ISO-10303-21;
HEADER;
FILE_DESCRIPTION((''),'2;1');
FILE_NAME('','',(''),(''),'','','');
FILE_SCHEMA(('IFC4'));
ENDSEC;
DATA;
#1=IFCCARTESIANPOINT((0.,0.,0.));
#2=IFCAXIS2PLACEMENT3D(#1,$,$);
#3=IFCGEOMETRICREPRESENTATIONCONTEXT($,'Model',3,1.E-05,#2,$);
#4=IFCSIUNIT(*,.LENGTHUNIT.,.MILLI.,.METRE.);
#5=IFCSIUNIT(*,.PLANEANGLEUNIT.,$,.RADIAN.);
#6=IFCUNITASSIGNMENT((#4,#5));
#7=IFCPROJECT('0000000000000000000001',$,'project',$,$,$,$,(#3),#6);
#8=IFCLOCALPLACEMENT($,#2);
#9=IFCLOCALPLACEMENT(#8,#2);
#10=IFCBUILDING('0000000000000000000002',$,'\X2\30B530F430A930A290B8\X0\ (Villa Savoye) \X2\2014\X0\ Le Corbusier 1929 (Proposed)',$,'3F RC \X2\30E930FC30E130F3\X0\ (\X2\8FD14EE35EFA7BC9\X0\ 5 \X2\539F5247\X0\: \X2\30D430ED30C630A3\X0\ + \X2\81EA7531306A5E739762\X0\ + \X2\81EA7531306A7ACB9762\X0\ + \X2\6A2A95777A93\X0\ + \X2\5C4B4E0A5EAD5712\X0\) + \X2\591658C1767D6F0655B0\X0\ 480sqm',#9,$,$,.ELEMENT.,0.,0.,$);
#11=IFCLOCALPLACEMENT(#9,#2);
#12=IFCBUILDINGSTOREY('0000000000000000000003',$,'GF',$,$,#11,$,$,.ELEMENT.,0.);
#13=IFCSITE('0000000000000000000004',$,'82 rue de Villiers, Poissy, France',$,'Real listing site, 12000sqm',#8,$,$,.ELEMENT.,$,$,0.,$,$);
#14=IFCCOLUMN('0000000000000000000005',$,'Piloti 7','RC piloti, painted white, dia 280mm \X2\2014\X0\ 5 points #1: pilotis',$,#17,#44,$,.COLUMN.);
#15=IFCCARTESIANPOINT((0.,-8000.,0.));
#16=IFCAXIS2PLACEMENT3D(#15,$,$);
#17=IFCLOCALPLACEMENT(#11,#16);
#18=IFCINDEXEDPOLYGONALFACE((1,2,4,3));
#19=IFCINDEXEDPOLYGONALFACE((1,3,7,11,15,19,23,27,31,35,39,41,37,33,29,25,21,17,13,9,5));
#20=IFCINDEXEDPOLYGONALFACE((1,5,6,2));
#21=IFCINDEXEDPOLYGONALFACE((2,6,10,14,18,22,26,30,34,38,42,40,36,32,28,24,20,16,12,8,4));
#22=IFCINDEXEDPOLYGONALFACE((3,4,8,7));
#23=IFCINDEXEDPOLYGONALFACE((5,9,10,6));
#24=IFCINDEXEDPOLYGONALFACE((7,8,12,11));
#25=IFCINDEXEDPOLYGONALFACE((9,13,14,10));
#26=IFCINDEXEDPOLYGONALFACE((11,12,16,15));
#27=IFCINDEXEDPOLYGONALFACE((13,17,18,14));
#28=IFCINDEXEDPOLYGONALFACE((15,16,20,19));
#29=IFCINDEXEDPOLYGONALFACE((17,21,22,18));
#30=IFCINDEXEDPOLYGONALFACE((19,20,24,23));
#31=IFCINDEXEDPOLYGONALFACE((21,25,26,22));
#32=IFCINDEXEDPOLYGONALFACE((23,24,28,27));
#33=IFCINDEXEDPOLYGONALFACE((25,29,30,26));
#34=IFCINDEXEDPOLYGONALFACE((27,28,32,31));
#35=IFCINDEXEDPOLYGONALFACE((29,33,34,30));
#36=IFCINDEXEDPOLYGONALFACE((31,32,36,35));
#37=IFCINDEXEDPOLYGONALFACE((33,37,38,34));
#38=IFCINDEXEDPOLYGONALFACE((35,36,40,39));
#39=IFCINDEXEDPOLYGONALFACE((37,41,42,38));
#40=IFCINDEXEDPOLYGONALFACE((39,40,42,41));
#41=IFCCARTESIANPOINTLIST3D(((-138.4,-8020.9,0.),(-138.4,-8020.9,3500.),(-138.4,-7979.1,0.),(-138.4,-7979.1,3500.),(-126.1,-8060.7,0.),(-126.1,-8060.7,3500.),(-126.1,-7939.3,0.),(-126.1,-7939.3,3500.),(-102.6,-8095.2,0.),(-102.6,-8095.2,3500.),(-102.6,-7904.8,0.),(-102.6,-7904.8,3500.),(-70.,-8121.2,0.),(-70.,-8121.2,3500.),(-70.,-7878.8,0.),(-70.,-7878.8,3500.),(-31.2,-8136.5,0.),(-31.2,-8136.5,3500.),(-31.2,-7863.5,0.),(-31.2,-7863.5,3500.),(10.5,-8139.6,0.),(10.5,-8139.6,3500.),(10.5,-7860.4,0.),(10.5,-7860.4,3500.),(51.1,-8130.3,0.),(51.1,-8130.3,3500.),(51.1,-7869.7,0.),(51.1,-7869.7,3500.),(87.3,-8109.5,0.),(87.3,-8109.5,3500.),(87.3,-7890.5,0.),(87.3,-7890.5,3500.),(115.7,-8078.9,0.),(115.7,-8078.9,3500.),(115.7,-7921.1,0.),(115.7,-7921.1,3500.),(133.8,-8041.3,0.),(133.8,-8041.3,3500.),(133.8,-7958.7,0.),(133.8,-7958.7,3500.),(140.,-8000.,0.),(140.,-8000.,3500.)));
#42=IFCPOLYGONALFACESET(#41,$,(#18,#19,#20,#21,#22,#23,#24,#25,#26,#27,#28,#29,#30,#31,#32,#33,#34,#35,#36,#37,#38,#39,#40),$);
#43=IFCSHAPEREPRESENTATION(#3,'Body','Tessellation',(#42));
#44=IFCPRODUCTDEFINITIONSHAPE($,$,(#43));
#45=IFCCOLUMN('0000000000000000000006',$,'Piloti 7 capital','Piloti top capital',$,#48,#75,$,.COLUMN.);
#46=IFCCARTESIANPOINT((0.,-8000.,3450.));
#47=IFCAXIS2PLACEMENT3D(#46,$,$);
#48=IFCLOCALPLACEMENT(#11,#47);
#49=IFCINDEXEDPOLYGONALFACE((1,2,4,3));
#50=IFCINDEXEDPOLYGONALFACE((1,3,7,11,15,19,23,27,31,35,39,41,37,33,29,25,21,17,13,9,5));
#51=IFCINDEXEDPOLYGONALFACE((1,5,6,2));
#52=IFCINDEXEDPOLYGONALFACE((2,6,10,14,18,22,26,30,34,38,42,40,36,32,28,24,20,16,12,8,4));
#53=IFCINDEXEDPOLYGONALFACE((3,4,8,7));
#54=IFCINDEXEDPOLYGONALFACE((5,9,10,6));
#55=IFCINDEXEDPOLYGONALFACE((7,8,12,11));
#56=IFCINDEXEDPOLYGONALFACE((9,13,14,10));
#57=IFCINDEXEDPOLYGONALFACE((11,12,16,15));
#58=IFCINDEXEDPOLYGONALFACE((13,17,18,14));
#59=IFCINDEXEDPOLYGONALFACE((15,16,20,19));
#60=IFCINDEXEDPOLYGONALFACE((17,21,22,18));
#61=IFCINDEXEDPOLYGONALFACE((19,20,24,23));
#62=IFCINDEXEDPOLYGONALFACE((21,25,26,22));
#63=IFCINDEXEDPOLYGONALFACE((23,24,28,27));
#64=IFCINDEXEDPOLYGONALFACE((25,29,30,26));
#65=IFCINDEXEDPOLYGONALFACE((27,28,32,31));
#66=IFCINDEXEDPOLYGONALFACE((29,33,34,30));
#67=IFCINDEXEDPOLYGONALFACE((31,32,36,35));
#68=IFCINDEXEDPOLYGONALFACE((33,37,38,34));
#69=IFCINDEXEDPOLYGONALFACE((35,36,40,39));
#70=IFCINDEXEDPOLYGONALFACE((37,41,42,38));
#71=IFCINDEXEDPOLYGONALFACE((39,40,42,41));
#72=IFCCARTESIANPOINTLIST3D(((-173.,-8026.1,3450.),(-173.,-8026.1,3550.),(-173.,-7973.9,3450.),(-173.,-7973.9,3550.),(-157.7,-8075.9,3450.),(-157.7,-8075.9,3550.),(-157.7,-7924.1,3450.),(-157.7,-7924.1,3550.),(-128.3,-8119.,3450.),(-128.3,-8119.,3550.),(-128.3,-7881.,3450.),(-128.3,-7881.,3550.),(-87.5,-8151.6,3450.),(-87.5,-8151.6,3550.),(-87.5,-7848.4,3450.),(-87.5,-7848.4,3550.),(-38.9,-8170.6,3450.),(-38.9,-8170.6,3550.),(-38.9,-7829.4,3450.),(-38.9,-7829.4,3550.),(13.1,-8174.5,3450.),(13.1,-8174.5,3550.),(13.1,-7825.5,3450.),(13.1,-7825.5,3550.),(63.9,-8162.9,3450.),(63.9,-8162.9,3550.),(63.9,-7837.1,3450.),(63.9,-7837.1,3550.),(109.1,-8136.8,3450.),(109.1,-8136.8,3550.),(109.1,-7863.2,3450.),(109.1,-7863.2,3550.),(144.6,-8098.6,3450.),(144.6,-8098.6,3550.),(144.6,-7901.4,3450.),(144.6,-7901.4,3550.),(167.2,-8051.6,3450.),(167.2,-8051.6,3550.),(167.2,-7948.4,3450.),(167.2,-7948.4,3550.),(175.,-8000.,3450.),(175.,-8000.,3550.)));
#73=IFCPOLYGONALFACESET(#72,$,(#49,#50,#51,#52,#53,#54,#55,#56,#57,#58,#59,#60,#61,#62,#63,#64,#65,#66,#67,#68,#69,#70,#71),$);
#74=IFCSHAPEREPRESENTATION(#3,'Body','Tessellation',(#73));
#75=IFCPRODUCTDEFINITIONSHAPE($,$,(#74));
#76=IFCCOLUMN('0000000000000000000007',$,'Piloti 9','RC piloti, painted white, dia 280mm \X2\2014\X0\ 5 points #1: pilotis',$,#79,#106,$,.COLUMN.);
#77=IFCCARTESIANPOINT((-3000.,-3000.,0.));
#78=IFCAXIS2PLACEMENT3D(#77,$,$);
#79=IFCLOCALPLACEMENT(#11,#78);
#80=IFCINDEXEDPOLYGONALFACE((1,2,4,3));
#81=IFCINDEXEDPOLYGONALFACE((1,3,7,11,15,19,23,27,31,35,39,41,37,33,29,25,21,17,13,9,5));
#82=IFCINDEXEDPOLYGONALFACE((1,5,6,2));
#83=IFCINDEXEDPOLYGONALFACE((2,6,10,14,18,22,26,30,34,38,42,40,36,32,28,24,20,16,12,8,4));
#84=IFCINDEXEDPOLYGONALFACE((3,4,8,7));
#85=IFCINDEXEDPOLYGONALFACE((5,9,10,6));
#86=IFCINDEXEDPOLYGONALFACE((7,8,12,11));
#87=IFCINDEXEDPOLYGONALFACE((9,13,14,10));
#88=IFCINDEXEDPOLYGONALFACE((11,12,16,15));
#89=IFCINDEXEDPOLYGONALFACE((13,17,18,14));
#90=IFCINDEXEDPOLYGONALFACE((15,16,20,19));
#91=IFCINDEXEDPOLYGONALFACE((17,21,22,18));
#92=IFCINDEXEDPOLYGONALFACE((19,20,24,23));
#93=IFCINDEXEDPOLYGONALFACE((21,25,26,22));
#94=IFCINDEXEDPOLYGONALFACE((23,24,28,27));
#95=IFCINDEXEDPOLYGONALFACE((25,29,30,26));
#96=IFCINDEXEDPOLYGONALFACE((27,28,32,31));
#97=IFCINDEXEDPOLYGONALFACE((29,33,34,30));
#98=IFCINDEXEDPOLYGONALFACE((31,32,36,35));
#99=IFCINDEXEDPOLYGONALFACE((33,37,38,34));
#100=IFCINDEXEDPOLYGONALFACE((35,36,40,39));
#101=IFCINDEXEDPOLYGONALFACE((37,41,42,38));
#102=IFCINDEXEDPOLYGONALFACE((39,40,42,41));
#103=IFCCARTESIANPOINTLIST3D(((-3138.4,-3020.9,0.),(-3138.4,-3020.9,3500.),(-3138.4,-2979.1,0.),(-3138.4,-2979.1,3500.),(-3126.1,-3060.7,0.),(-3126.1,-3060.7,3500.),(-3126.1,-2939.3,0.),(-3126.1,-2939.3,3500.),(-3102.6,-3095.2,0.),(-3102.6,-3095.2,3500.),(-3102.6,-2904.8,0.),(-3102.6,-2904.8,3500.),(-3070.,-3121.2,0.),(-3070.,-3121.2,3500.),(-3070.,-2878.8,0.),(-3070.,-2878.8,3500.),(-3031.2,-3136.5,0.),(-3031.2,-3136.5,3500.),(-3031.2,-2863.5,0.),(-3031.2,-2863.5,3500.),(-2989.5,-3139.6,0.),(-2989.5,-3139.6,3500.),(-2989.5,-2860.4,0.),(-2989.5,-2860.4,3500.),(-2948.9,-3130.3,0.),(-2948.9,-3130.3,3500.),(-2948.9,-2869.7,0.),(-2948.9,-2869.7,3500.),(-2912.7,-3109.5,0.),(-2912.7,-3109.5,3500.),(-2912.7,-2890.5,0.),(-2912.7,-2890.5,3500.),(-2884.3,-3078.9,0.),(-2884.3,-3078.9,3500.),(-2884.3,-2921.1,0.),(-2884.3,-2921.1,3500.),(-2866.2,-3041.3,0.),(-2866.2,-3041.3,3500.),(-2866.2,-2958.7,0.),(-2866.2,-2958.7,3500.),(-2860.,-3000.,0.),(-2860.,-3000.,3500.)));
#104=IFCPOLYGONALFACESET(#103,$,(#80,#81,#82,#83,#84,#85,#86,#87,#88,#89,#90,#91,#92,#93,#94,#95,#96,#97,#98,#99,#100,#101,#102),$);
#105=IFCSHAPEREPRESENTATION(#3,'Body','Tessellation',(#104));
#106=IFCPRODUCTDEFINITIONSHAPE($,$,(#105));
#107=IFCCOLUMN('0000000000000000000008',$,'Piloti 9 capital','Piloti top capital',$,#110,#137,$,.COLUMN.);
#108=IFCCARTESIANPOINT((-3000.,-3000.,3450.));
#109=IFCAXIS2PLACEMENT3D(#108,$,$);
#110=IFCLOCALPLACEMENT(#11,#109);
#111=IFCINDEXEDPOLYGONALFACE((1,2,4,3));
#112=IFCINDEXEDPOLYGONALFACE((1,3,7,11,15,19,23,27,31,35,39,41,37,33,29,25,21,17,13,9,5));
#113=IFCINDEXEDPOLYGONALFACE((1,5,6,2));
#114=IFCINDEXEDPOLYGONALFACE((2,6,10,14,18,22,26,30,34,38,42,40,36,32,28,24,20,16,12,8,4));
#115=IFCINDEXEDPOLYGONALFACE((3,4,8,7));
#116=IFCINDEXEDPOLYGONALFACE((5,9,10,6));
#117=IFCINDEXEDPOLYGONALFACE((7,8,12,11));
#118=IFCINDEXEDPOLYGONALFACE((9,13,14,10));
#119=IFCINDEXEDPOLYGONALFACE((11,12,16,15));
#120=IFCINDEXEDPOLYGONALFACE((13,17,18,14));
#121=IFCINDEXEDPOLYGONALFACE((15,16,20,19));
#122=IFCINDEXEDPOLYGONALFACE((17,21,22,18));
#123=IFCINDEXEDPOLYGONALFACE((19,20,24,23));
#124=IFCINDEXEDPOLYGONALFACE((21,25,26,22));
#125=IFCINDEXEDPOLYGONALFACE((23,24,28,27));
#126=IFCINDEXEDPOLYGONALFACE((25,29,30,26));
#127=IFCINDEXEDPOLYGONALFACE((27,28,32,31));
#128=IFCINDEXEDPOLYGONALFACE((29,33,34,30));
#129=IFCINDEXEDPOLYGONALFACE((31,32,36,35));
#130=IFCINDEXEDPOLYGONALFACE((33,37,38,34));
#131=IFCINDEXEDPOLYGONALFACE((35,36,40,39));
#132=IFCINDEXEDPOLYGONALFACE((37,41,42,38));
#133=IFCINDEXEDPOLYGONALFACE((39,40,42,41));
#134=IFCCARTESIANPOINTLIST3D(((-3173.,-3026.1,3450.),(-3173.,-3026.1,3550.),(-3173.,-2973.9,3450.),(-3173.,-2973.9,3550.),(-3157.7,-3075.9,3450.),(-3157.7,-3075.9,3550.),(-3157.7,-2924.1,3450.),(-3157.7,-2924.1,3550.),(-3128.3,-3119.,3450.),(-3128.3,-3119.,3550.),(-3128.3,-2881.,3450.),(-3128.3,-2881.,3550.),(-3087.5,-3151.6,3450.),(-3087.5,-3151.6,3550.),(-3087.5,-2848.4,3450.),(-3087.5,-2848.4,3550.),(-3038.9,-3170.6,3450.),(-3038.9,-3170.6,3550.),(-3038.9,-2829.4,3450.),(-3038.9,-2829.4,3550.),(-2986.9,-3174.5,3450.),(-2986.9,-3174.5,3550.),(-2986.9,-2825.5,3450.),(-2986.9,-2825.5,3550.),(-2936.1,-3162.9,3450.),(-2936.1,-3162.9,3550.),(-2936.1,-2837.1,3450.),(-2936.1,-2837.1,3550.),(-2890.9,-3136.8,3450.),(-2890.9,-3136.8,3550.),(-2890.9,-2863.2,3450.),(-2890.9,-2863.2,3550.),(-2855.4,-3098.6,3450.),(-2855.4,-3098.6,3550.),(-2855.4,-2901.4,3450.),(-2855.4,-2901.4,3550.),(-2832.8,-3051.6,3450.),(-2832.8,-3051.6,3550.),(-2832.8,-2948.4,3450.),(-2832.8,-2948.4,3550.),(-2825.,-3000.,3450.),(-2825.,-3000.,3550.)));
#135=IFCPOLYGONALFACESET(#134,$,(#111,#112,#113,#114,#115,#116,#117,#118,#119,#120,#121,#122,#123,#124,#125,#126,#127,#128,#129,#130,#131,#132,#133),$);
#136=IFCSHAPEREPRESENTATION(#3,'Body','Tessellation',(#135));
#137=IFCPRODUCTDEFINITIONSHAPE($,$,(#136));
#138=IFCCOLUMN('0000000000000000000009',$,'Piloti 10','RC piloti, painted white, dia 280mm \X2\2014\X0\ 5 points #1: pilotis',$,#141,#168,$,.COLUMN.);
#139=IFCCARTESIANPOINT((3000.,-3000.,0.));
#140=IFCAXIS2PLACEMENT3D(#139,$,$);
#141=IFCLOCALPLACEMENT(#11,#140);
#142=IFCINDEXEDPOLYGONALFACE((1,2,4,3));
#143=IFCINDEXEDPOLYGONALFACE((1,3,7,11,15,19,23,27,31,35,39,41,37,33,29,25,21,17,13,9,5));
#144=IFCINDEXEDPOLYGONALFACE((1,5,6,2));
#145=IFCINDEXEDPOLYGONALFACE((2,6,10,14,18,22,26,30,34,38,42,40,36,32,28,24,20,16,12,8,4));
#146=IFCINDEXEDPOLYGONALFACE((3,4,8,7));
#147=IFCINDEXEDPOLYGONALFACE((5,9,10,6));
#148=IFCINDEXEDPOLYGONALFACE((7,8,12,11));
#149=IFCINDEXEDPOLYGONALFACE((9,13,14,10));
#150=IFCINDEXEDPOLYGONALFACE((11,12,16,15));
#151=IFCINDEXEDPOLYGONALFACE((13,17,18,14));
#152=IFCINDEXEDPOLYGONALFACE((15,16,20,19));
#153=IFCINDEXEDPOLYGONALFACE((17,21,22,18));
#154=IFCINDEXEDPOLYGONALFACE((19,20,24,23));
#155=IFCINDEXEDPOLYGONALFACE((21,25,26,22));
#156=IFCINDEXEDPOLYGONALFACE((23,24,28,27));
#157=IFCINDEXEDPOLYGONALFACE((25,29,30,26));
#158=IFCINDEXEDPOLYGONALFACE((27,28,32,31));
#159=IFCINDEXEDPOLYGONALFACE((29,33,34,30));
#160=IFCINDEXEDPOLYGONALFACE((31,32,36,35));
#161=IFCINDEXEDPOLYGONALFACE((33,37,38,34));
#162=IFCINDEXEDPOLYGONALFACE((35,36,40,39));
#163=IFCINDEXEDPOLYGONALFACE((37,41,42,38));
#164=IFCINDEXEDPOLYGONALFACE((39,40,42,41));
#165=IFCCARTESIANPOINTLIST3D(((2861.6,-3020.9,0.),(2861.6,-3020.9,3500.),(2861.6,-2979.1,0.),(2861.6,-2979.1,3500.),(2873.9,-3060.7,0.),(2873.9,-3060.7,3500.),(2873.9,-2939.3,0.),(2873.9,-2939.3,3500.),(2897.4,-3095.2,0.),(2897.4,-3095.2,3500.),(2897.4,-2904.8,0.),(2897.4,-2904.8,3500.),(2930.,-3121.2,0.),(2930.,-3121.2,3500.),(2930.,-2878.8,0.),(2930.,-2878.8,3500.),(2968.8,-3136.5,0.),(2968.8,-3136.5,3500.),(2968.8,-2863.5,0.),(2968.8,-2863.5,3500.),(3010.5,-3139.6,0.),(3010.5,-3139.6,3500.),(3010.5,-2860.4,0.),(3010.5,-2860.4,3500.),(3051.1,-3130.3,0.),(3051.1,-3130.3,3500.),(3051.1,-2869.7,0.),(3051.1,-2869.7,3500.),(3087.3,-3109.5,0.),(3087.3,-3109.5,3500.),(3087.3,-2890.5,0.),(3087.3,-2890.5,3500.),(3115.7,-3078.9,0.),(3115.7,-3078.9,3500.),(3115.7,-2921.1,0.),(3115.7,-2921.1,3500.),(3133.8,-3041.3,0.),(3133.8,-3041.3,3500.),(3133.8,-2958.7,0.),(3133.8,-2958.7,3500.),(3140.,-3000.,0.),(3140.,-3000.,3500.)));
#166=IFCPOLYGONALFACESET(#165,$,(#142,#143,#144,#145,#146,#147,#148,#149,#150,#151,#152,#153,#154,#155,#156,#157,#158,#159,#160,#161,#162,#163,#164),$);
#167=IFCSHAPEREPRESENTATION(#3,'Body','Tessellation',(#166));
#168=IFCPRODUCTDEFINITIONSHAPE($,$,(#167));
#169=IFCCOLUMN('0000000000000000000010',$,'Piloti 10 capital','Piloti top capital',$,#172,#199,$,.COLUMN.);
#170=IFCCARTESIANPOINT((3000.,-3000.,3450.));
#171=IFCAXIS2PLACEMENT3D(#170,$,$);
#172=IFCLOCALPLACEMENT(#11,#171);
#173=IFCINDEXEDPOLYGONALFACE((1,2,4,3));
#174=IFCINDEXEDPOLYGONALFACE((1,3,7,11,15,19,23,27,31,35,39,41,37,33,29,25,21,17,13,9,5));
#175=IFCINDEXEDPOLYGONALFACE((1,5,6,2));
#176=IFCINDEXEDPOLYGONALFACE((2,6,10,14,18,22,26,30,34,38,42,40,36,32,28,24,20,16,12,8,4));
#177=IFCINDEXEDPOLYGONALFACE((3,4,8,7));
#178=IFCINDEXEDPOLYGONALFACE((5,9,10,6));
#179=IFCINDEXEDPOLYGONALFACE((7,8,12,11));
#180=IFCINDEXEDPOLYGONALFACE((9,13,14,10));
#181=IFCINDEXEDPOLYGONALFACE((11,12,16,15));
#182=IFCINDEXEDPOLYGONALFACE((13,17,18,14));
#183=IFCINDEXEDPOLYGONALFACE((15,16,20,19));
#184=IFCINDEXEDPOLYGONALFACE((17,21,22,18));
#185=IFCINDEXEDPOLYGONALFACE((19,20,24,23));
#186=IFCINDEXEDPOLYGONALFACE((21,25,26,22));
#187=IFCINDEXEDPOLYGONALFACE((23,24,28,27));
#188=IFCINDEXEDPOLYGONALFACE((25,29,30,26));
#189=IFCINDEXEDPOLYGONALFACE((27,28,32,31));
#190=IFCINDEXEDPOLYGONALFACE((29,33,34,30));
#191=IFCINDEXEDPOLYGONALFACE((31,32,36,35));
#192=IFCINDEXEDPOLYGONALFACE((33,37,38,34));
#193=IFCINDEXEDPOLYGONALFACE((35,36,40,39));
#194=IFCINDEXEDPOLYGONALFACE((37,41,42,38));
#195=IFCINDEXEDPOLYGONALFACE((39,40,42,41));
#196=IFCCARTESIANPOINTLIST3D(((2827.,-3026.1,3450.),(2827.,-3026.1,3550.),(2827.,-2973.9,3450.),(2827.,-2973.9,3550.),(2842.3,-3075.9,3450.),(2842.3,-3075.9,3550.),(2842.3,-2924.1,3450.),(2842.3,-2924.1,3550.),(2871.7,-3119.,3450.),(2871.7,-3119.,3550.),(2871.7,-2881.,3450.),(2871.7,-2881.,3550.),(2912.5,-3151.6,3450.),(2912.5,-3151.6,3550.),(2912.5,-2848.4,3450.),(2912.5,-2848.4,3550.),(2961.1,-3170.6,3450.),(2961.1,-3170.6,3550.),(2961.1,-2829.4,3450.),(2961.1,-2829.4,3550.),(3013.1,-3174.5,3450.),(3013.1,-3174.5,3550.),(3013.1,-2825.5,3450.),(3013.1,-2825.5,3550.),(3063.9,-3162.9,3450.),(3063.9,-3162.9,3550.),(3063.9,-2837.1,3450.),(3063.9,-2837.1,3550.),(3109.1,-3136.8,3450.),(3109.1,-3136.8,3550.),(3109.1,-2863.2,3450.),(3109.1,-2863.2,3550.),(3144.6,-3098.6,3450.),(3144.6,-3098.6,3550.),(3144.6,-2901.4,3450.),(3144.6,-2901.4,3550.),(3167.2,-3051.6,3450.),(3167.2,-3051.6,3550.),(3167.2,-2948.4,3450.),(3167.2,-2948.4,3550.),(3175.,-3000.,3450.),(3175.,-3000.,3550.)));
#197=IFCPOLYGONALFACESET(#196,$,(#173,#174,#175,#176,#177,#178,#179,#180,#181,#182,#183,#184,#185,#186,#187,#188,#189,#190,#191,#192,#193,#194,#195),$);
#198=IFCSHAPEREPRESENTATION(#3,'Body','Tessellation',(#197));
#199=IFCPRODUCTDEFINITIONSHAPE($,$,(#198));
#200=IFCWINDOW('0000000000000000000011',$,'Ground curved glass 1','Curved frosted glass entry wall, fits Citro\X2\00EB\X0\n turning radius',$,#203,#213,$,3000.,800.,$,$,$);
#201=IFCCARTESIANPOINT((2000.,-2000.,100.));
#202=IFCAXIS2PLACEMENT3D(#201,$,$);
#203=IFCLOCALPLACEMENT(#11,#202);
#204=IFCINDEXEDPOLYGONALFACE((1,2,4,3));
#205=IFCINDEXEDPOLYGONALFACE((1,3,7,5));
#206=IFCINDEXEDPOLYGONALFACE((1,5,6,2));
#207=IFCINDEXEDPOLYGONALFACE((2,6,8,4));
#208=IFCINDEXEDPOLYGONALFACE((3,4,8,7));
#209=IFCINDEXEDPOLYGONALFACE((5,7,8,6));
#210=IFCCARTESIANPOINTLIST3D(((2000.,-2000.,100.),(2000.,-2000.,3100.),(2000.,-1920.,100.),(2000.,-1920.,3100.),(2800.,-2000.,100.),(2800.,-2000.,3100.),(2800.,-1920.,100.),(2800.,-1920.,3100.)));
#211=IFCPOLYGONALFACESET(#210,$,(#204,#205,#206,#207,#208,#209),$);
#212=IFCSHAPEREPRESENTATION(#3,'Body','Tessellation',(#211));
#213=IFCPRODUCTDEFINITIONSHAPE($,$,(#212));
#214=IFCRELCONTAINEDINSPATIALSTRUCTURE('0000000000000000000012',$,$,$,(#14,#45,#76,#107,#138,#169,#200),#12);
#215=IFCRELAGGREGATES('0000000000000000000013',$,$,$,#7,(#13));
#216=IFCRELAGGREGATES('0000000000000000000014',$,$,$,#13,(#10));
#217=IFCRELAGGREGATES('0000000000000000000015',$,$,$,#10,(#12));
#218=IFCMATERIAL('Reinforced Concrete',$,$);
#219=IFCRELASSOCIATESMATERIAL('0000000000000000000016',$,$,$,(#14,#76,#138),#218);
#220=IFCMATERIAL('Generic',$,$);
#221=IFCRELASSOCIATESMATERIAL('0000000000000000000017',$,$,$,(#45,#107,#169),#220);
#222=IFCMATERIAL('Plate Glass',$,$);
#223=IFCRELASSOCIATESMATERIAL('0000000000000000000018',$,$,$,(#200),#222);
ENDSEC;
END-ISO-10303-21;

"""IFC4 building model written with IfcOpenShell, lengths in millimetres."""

from ifc_helpers import new_model, si_unit, frame, frame_2d, origin, origin_2d, place, context, project, spatial, rectangle, circle, extrude, material, element, save


model = new_model("IFC4")

# Units and contexts
model_context = context("Model", 3, precision=1e-05, world=origin())
ifc_project = project(units=[si_unit("LENGTHUNIT", "METRE", prefix="MILLI"), si_unit("PLANEANGLEUNIT", "RADIAN")], contexts=[model_context])

# Site, building, storey
site_placement = place(None, origin())
site = spatial("IfcSite", under=ifc_project, at=site_placement, Name="82 rue de Villiers, Poissy, France", ObjectType="Real listing site, 12000sqm", CompositionType="ELEMENT", RefElevation=0.0)
building_placement = place(site_placement, origin())
building = spatial("IfcBuilding", under=site, at=building_placement, Name="サヴォア邸 (Villa Savoye) — Le Corbusier 1929 (Proposed)", ObjectType="3F RC ラーメン (近代建築 5 原則: ピロティ + 自由な平面 + 自由な立面 + 横長窓 + 屋上庭園) + 外壁白漆喰 480sqm", CompositionType="ELEMENT", ElevationOfRefHeight=0.0, ElevationOfTerrain=0.0)
storey_placement = place(building_placement, origin())
storey = spatial("IfcBuildingStorey", under=building, at=storey_placement, Name="GF", CompositionType="ELEMENT", Elevation=0.0)

# Columns
ifc_material_1 = material(Name="Reinforced Concrete")
column_1_placement = place(storey_placement, frame((0.0, -8000.0, 0.0)))
element("IfcColumn", 1, at=column_1_placement, inside=storey, material=ifc_material_1, Name="Piloti 7", Description="RC piloti, painted white, dia 280mm — 5 points #1: pilotis", PredefinedType="COLUMN", context=model_context, shape_type="SweptSolid", body=[
    extrude(circle(Radius=140.0, at=origin_2d()), frame((0.0, -8000.0, 0.0)), (0.0, 0.0, 1.0), 3500.0),
])
ifc_material_2 = material(Name="Generic")
column_2_placement = place(storey_placement, frame((0.0, -8000.0, 3450.0)))
element("IfcColumn", 2, at=column_2_placement, inside=storey, material=ifc_material_2, Name="Piloti 7 capital", Description="Piloti top capital", PredefinedType="COLUMN", context=model_context, shape_type="SweptSolid", body=[
    extrude(circle(Radius=175.0, at=origin_2d()), frame((0.0, -8000.0, 3450.0)), (0.0, 0.0, 1.0), 100.0),
])
column_3_placement = place(storey_placement, frame((-3000.0, -3000.0, 0.0)))
element("IfcColumn", 3, at=column_3_placement, inside=storey, material=ifc_material_1, Name="Piloti 9", Description="RC piloti, painted white, dia 280mm — 5 points #1: pilotis", PredefinedType="COLUMN", context=model_context, shape_type="SweptSolid", body=[
    extrude(circle(Radius=140.0, at=origin_2d()), frame((-3000.0, -3000.0, 0.0)), (0.0, 0.0, 1.0), 3500.0),
])
column_4_placement = place(storey_placement, frame((-3000.0, -3000.0, 3450.0)))
element("IfcColumn", 4, at=column_4_placement, inside=storey, material=ifc_material_2, Name="Piloti 9 capital", Description="Piloti top capital", PredefinedType="COLUMN", context=model_context, shape_type="SweptSolid", body=[
    extrude(circle(Radius=175.0, at=origin_2d()), frame((-3000.0, -3000.0, 3450.0)), (0.0, 0.0, 1.0), 100.0),
])
column_5_placement = place(storey_placement, frame((3000.0, -3000.0, 0.0)))
element("IfcColumn", 5, at=column_5_placement, inside=storey, material=ifc_material_1, Name="Piloti 10", Description="RC piloti, painted white, dia 280mm — 5 points #1: pilotis", PredefinedType="COLUMN", context=model_context, shape_type="SweptSolid", body=[
    extrude(circle(Radius=140.0, at=origin_2d()), frame((3000.0, -3000.0, 0.0)), (0.0, 0.0, 1.0), 3500.0),
])
column_6_placement = place(storey_placement, frame((3000.0, -3000.0, 3450.0)))
element("IfcColumn", 6, at=column_6_placement, inside=storey, material=ifc_material_2, Name="Piloti 10 capital", Description="Piloti top capital", PredefinedType="COLUMN", context=model_context, shape_type="SweptSolid", body=[
    extrude(circle(Radius=175.0, at=origin_2d()), frame((3000.0, -3000.0, 3450.0)), (0.0, 0.0, 1.0), 100.0),
])

# Window
ifc_material_3 = material(Name="Plate Glass")
window_1_placement = place(storey_placement, frame((2000.0, -2000.0, 100.0)))
element("IfcWindow", 7, at=window_1_placement, inside=storey, material=ifc_material_3, Name="Ground curved glass 1", Description="Curved frosted glass entry wall, fits Citroën turning radius", OverallHeight=3000.0, OverallWidth=800.0, context=model_context, shape_type="SweptSolid", body=[
    extrude(rectangle(XDim=800.0, YDim=80.0, at=frame_2d((400.0, 40.0))), frame((2000.0, -2000.0, 100.0)), (0.0, 0.0, 1.0), 3000.0),
])

save(model, "model.ifc")
